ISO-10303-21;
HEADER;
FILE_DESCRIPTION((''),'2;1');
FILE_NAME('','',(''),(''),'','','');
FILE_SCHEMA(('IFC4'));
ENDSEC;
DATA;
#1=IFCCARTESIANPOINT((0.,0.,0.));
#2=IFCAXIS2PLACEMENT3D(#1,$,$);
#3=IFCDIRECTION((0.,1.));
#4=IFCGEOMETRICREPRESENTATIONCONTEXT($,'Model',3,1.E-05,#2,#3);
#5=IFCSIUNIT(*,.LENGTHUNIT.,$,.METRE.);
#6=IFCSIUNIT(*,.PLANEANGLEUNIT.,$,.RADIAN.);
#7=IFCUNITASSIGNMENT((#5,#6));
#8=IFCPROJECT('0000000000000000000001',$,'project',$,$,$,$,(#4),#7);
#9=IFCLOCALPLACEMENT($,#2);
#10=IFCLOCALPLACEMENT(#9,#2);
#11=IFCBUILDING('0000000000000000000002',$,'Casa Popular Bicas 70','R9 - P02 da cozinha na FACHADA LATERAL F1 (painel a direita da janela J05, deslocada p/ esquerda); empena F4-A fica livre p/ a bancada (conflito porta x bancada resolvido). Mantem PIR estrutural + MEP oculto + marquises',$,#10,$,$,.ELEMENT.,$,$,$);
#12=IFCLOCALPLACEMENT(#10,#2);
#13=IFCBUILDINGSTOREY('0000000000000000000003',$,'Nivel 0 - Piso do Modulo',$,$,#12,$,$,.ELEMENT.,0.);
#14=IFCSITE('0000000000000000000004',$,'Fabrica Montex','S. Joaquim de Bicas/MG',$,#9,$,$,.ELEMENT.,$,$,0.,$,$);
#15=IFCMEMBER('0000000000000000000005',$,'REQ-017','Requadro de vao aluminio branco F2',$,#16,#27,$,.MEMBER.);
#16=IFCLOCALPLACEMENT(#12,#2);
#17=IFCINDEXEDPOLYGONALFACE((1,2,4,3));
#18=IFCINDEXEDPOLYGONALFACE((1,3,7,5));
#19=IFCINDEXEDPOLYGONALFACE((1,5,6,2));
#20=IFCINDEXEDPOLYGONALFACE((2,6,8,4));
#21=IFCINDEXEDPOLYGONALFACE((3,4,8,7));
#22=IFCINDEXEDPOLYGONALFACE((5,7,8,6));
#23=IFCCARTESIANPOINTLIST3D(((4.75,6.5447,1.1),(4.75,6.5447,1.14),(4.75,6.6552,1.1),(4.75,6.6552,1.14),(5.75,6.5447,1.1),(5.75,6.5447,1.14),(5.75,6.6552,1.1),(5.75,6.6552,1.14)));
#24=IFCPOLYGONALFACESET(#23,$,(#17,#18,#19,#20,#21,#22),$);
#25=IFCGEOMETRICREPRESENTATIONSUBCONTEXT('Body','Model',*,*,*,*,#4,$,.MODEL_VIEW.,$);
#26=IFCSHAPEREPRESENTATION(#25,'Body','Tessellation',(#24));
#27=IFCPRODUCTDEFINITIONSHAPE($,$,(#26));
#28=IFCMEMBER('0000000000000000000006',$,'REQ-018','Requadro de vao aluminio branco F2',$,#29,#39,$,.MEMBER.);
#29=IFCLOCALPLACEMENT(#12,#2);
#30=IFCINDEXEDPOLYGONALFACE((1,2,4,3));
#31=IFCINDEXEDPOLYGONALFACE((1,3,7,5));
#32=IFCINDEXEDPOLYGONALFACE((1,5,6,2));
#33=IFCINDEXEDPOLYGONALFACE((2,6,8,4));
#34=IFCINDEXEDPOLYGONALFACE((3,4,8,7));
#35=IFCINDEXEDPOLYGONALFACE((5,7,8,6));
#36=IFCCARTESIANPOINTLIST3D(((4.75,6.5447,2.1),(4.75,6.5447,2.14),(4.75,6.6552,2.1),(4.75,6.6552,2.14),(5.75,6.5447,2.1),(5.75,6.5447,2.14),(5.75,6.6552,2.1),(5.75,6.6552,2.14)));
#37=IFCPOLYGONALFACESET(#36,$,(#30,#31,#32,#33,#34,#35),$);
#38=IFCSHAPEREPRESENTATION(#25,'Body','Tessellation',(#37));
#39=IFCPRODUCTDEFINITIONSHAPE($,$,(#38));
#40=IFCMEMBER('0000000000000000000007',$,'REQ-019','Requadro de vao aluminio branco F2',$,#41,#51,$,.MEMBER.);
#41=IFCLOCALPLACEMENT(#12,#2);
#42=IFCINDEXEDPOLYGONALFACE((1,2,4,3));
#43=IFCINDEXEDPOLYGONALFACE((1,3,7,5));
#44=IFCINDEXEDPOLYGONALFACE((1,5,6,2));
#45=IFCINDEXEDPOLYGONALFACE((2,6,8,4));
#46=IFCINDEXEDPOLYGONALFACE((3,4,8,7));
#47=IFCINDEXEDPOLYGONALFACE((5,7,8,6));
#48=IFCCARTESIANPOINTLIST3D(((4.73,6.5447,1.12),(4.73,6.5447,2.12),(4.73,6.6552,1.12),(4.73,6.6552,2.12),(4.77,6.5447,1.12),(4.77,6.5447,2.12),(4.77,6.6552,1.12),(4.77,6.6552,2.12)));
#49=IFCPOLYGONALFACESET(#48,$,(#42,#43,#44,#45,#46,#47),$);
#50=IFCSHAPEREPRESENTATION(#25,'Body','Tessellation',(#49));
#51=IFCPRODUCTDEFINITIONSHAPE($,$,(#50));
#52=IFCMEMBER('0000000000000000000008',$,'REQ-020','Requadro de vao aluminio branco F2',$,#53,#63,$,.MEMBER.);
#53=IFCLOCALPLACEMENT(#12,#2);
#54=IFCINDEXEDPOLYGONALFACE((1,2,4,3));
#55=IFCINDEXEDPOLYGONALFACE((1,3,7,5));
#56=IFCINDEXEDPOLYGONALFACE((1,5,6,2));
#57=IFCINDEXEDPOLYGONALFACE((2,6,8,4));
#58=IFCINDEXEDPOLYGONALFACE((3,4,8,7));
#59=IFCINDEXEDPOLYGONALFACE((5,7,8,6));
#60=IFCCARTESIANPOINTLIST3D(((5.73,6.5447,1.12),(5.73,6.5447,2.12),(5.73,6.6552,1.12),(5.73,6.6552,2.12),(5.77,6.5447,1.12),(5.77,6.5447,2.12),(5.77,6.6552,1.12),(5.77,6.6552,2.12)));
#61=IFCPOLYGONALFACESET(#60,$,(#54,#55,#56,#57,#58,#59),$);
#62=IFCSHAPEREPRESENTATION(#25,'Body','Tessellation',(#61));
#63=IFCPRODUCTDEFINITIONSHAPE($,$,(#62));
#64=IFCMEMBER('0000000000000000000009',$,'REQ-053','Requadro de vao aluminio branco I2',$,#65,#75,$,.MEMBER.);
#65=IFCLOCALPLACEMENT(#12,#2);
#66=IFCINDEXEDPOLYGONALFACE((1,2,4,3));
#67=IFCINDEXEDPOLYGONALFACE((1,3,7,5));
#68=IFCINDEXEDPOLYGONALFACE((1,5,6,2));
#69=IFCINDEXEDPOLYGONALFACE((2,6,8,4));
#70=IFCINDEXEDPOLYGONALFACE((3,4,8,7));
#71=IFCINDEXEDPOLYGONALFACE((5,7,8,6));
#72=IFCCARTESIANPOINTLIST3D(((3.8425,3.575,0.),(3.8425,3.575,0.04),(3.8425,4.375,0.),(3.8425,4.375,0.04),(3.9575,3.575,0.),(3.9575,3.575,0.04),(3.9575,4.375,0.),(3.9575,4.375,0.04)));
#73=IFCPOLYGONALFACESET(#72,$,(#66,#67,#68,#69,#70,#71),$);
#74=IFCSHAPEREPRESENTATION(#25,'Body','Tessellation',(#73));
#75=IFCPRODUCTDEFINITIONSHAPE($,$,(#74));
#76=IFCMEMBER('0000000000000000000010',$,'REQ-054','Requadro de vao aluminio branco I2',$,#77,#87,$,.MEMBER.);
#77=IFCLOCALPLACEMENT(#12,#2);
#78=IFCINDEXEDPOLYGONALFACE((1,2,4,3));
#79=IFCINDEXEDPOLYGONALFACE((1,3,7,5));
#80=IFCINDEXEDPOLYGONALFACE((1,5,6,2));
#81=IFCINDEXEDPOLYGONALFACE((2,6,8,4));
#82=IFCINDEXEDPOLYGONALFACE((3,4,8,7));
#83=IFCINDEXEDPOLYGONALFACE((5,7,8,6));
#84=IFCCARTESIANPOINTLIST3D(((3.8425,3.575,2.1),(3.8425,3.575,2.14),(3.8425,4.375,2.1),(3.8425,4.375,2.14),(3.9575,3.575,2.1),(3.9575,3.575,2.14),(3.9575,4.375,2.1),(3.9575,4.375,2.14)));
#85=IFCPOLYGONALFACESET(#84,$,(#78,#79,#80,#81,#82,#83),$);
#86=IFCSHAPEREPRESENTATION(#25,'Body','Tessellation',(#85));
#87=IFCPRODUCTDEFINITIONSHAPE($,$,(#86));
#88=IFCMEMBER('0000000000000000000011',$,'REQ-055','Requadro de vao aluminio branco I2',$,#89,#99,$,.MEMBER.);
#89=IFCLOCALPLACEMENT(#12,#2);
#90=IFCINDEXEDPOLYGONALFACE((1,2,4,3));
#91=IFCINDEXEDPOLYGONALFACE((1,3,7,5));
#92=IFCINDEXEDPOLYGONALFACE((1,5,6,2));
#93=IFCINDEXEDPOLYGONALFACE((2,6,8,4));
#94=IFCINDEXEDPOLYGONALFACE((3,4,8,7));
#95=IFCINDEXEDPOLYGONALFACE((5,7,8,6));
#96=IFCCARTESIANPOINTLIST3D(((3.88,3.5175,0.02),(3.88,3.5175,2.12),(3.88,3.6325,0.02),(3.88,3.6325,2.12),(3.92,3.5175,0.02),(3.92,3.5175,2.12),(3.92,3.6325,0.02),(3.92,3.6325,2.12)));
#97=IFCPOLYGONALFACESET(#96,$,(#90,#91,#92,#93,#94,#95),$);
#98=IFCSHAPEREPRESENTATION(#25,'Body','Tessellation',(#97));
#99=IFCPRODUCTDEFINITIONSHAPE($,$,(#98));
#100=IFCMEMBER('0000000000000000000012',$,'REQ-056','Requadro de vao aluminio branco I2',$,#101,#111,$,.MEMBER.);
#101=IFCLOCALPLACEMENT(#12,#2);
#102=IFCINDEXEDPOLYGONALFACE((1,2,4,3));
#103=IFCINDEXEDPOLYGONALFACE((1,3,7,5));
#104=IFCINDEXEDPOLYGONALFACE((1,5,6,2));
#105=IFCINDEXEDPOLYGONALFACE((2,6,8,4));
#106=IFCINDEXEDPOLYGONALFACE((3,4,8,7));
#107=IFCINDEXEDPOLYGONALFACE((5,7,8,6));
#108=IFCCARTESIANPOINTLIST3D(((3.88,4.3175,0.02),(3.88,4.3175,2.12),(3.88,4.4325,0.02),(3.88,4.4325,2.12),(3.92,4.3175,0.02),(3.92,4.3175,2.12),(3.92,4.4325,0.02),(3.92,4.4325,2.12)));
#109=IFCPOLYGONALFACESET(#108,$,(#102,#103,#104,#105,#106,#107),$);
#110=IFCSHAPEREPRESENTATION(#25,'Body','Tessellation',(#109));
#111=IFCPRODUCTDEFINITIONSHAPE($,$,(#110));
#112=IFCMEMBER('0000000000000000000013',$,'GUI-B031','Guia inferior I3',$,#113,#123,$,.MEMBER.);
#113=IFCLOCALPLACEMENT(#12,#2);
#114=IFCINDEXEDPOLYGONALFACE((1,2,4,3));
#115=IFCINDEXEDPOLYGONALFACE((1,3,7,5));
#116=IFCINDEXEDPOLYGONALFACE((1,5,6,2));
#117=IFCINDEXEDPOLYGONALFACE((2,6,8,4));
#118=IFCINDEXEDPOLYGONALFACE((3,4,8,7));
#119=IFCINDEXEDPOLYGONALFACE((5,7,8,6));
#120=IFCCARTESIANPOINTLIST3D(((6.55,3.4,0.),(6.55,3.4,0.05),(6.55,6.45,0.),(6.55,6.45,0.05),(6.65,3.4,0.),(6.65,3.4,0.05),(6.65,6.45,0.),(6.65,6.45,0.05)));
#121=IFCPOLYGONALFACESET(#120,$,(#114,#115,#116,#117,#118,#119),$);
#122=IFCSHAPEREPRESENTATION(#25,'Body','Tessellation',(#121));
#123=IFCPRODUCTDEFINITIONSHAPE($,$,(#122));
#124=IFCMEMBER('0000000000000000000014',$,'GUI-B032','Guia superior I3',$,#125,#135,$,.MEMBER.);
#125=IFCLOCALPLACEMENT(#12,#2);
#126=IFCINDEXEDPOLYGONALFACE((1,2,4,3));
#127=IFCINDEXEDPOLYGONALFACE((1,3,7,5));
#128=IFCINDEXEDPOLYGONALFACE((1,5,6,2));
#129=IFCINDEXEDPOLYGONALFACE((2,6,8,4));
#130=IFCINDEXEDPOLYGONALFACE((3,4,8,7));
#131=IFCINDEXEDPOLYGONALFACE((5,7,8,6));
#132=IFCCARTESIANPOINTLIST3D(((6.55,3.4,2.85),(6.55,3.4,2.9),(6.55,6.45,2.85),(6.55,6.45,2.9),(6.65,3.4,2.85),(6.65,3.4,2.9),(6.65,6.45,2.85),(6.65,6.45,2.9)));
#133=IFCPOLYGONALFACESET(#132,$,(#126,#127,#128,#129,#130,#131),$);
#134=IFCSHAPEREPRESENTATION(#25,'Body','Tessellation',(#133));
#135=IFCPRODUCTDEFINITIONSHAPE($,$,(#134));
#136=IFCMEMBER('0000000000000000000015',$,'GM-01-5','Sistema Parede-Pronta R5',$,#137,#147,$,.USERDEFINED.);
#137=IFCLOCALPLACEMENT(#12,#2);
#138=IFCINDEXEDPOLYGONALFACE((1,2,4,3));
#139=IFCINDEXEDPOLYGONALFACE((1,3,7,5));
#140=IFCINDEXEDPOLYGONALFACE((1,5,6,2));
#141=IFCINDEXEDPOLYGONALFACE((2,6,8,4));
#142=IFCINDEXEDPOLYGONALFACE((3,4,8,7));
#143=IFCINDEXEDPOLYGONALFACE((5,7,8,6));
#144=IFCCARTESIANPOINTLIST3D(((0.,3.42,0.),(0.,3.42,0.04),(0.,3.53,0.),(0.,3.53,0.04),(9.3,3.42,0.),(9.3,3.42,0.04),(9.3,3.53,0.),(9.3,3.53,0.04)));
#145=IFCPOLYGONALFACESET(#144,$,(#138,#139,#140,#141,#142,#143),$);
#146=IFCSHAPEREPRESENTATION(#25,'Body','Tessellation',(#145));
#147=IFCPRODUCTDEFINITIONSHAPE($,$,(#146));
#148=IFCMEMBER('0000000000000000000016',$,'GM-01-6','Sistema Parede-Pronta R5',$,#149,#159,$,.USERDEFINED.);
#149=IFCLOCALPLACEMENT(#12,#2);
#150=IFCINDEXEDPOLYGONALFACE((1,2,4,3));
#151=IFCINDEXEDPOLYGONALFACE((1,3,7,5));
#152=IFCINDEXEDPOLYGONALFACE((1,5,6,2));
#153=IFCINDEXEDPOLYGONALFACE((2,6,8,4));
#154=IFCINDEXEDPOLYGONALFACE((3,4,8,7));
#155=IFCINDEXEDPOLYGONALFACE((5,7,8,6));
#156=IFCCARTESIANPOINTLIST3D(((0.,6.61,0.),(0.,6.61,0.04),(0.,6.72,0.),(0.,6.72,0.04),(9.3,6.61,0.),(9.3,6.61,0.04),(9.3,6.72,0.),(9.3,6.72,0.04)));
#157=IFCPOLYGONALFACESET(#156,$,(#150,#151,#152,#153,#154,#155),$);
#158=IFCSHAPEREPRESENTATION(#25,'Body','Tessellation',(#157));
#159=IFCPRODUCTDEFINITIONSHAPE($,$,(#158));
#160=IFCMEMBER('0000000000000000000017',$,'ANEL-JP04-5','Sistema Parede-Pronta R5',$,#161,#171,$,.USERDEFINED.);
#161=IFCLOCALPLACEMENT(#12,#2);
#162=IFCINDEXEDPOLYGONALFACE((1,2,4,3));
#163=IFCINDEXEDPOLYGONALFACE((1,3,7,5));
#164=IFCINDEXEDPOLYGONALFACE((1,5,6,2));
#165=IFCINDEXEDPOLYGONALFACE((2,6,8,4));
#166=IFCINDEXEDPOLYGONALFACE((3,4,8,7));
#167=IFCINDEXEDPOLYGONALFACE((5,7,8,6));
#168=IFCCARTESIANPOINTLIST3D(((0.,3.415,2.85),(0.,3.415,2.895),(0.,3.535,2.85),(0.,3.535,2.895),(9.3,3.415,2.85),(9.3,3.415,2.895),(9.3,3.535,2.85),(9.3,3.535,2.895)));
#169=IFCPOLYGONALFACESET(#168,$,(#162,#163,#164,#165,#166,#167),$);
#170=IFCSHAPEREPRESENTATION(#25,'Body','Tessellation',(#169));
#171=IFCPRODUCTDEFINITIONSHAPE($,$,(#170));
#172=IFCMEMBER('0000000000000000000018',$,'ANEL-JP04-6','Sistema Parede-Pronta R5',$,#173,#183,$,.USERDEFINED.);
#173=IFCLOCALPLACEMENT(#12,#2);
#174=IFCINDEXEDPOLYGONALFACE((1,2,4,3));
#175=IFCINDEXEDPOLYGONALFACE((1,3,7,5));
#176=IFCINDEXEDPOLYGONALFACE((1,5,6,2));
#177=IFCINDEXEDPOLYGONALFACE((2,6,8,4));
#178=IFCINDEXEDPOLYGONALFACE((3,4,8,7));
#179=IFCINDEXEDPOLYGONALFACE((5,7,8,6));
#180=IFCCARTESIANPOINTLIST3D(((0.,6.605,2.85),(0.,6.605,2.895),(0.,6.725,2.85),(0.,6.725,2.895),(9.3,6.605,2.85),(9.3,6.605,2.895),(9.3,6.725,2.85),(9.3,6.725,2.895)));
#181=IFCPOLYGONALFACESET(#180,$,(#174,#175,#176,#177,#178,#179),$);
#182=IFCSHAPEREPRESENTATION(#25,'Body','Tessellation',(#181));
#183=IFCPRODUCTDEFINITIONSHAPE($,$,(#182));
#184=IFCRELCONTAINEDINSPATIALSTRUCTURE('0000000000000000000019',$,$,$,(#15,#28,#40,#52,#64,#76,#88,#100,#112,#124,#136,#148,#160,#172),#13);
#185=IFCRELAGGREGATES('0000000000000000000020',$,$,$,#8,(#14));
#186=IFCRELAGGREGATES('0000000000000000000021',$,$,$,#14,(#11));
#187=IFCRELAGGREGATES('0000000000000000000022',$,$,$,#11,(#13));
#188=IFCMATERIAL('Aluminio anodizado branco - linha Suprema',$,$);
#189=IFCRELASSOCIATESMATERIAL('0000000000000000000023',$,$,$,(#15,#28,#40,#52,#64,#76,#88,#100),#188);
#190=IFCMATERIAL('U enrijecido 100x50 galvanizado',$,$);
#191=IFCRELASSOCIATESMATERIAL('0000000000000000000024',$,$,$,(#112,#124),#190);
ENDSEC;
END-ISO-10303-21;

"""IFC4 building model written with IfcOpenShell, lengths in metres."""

from ifc_helpers import new_model, si_unit, direction, frame, origin, origin_2d, place, context, subcontext, project, spatial, rectangle, extrude, material, element, save


model = new_model("IFC4")

# Units and contexts
model_context_1 = context("Model", 3, precision=1e-05, world=origin(), true_north=direction((0.0, 1.0)))
body_context_1 = subcontext(model_context_1, "Body", "Model", "MODEL_VIEW")
ifc_project = project(units=[si_unit("LENGTHUNIT", "METRE"), si_unit("PLANEANGLEUNIT", "RADIAN")], contexts=[model_context_1])

# Site, building, storey
site_placement = place(None, origin())
site = spatial("IfcSite", under=ifc_project, at=site_placement, Name="Fabrica Montex", Description="S. Joaquim de Bicas/MG", CompositionType="ELEMENT", RefElevation=0.0)
building_placement = place(site_placement, origin())
building = spatial("IfcBuilding", under=site, at=building_placement, Name="Casa Popular Bicas 70", Description="R9 - P02 da cozinha na FACHADA LATERAL F1 (painel a direita da janela J05, deslocada p/ esquerda); empena F4-A fica livre p/ a bancada (conflito porta x bancada resolvido). Mantem PIR estrutural + MEP oculto + marquises", CompositionType="ELEMENT")
storey_placement = place(building_placement, origin())
storey = spatial("IfcBuildingStorey", under=building, at=storey_placement, Name="Nivel 0 - Piso do Modulo", CompositionType="ELEMENT", Elevation=0.0)

# Members
ifc_material_1 = material(Name="Aluminio anodizado branco - linha Suprema")
for number, where, z_axis, x_axis, name in (
    (1, (4.75, 6.6, 1.12), (1.0, 0.0, 0.0), (0.0, 0.0, 1.0), "REQ-017"),
    (2, (4.75, 6.6, 2.12), (1.0, 0.0, 0.0), (0.0, 0.0, 1.0), "REQ-018"),
    (3, (4.75, 6.6, 1.12), (0.0, 0.0, 1.0), (1.0, 0.0, 0.0), "REQ-019"),
    (4, (5.75, 6.6, 1.12), (0.0, 0.0, 1.0), (1.0, 0.0, 0.0), "REQ-020"),
):
    element("IfcMember", number, at=place(storey_placement, frame(where, z_axis=z_axis, x_axis=x_axis)), inside=storey, material=ifc_material_1, Name=name, Description="Requadro de vao aluminio branco F2", PredefinedType="MEMBER", context=body_context_1, shape_type="SweptSolid", body=[
        extrude(rectangle(XDim=0.04, YDim=0.1105, at=origin_2d()), origin(), (0.0, 0.0, 1.0), 1.0),
    ])
for number, where, z_axis, x_axis, name in (
    (5, (3.9, 3.575, 0.02), (0.0, 1.0, 0.0), (0.0, 0.0, 1.0), "REQ-053"),
    (6, (3.9, 3.575, 2.12), (0.0, 1.0, 0.0), (0.0, 0.0, 1.0), "REQ-054"),
):
    element("IfcMember", number, at=place(storey_placement, frame(where, z_axis=z_axis, x_axis=x_axis)), inside=storey, material=ifc_material_1, Name=name, Description="Requadro de vao aluminio branco I2", PredefinedType="MEMBER", context=body_context_1, shape_type="SweptSolid", body=[
        extrude(rectangle(XDim=0.04, YDim=0.115, at=origin_2d()), origin(), (0.0, 0.0, 1.0), 0.8),
    ])
for number, where, z_axis, x_axis, name in (
    (7, (3.9, 3.575, 0.02), (0.0, 0.0, 1.0), (1.0, 0.0, 0.0), "REQ-055"),
    (8, (3.9, 4.375, 0.02), (0.0, 0.0, 1.0), (1.0, 0.0, 0.0), "REQ-056"),
):
    element("IfcMember", number, at=place(storey_placement, frame(where, z_axis=z_axis, x_axis=x_axis)), inside=storey, material=ifc_material_1, Name=name, Description="Requadro de vao aluminio branco I2", PredefinedType="MEMBER", context=body_context_1, shape_type="SweptSolid", body=[
        extrude(rectangle(XDim=0.04, YDim=0.115, at=origin_2d()), origin(), (0.0, 0.0, 1.0), 2.1),
    ])
ifc_material_2 = material(Name="U enrijecido 100x50 galvanizado")
for number, where, z_axis, x_axis, name, description in (
    (9, (6.6, 3.4, 0.025), (0.0, 1.0, 0.0), (0.0, 0.0, 1.0), "GUI-B031", "Guia inferior I3"),
    (10, (6.6, 3.4, 2.875), (0.0, 1.0, 0.0), (0.0, 0.0, 1.0), "GUI-B032", "Guia superior I3"),
):
    element("IfcMember", number, at=place(storey_placement, frame(where, z_axis=z_axis, x_axis=x_axis)), inside=storey, material=ifc_material_2, Name=name, Description=description, PredefinedType="MEMBER", context=body_context_1, shape_type="SweptSolid", body=[
        extrude(rectangle(XDim=0.05, YDim=0.1, at=origin_2d()), origin(), (0.0, 0.0, 1.0), 3.05),
    ])
for number, where, name in (
    (11, (4.65, 3.475, 0.0), "GM-01-5"),
    (12, (4.65, 6.665, 0.0), "GM-01-6"),
):
    element("IfcMember", number, at=place(storey_placement, frame(where)), inside=storey, Name=name, Description="Sistema Parede-Pronta R5", PredefinedType="USERDEFINED", context=body_context_1, shape_type="SweptSolid", body=[
        extrude(rectangle(XDim=9.3, YDim=0.11, at=origin_2d()), origin(), (0.0, 0.0, 1.0), 0.04),
    ])
for number, where, name in (
    (13, (4.65, 3.475, 2.85), "ANEL-JP04-5"),
    (14, (4.65, 6.665, 2.85), "ANEL-JP04-6"),
):
    element("IfcMember", number, at=place(storey_placement, frame(where)), inside=storey, Name=name, Description="Sistema Parede-Pronta R5", PredefinedType="USERDEFINED", context=body_context_1, shape_type="SweptSolid", body=[
        extrude(rectangle(XDim=9.3, YDim=0.12, at=origin_2d()), origin(), (0.0, 0.0, 1.0), 0.045),
    ])

save(model, "model.ifc")
